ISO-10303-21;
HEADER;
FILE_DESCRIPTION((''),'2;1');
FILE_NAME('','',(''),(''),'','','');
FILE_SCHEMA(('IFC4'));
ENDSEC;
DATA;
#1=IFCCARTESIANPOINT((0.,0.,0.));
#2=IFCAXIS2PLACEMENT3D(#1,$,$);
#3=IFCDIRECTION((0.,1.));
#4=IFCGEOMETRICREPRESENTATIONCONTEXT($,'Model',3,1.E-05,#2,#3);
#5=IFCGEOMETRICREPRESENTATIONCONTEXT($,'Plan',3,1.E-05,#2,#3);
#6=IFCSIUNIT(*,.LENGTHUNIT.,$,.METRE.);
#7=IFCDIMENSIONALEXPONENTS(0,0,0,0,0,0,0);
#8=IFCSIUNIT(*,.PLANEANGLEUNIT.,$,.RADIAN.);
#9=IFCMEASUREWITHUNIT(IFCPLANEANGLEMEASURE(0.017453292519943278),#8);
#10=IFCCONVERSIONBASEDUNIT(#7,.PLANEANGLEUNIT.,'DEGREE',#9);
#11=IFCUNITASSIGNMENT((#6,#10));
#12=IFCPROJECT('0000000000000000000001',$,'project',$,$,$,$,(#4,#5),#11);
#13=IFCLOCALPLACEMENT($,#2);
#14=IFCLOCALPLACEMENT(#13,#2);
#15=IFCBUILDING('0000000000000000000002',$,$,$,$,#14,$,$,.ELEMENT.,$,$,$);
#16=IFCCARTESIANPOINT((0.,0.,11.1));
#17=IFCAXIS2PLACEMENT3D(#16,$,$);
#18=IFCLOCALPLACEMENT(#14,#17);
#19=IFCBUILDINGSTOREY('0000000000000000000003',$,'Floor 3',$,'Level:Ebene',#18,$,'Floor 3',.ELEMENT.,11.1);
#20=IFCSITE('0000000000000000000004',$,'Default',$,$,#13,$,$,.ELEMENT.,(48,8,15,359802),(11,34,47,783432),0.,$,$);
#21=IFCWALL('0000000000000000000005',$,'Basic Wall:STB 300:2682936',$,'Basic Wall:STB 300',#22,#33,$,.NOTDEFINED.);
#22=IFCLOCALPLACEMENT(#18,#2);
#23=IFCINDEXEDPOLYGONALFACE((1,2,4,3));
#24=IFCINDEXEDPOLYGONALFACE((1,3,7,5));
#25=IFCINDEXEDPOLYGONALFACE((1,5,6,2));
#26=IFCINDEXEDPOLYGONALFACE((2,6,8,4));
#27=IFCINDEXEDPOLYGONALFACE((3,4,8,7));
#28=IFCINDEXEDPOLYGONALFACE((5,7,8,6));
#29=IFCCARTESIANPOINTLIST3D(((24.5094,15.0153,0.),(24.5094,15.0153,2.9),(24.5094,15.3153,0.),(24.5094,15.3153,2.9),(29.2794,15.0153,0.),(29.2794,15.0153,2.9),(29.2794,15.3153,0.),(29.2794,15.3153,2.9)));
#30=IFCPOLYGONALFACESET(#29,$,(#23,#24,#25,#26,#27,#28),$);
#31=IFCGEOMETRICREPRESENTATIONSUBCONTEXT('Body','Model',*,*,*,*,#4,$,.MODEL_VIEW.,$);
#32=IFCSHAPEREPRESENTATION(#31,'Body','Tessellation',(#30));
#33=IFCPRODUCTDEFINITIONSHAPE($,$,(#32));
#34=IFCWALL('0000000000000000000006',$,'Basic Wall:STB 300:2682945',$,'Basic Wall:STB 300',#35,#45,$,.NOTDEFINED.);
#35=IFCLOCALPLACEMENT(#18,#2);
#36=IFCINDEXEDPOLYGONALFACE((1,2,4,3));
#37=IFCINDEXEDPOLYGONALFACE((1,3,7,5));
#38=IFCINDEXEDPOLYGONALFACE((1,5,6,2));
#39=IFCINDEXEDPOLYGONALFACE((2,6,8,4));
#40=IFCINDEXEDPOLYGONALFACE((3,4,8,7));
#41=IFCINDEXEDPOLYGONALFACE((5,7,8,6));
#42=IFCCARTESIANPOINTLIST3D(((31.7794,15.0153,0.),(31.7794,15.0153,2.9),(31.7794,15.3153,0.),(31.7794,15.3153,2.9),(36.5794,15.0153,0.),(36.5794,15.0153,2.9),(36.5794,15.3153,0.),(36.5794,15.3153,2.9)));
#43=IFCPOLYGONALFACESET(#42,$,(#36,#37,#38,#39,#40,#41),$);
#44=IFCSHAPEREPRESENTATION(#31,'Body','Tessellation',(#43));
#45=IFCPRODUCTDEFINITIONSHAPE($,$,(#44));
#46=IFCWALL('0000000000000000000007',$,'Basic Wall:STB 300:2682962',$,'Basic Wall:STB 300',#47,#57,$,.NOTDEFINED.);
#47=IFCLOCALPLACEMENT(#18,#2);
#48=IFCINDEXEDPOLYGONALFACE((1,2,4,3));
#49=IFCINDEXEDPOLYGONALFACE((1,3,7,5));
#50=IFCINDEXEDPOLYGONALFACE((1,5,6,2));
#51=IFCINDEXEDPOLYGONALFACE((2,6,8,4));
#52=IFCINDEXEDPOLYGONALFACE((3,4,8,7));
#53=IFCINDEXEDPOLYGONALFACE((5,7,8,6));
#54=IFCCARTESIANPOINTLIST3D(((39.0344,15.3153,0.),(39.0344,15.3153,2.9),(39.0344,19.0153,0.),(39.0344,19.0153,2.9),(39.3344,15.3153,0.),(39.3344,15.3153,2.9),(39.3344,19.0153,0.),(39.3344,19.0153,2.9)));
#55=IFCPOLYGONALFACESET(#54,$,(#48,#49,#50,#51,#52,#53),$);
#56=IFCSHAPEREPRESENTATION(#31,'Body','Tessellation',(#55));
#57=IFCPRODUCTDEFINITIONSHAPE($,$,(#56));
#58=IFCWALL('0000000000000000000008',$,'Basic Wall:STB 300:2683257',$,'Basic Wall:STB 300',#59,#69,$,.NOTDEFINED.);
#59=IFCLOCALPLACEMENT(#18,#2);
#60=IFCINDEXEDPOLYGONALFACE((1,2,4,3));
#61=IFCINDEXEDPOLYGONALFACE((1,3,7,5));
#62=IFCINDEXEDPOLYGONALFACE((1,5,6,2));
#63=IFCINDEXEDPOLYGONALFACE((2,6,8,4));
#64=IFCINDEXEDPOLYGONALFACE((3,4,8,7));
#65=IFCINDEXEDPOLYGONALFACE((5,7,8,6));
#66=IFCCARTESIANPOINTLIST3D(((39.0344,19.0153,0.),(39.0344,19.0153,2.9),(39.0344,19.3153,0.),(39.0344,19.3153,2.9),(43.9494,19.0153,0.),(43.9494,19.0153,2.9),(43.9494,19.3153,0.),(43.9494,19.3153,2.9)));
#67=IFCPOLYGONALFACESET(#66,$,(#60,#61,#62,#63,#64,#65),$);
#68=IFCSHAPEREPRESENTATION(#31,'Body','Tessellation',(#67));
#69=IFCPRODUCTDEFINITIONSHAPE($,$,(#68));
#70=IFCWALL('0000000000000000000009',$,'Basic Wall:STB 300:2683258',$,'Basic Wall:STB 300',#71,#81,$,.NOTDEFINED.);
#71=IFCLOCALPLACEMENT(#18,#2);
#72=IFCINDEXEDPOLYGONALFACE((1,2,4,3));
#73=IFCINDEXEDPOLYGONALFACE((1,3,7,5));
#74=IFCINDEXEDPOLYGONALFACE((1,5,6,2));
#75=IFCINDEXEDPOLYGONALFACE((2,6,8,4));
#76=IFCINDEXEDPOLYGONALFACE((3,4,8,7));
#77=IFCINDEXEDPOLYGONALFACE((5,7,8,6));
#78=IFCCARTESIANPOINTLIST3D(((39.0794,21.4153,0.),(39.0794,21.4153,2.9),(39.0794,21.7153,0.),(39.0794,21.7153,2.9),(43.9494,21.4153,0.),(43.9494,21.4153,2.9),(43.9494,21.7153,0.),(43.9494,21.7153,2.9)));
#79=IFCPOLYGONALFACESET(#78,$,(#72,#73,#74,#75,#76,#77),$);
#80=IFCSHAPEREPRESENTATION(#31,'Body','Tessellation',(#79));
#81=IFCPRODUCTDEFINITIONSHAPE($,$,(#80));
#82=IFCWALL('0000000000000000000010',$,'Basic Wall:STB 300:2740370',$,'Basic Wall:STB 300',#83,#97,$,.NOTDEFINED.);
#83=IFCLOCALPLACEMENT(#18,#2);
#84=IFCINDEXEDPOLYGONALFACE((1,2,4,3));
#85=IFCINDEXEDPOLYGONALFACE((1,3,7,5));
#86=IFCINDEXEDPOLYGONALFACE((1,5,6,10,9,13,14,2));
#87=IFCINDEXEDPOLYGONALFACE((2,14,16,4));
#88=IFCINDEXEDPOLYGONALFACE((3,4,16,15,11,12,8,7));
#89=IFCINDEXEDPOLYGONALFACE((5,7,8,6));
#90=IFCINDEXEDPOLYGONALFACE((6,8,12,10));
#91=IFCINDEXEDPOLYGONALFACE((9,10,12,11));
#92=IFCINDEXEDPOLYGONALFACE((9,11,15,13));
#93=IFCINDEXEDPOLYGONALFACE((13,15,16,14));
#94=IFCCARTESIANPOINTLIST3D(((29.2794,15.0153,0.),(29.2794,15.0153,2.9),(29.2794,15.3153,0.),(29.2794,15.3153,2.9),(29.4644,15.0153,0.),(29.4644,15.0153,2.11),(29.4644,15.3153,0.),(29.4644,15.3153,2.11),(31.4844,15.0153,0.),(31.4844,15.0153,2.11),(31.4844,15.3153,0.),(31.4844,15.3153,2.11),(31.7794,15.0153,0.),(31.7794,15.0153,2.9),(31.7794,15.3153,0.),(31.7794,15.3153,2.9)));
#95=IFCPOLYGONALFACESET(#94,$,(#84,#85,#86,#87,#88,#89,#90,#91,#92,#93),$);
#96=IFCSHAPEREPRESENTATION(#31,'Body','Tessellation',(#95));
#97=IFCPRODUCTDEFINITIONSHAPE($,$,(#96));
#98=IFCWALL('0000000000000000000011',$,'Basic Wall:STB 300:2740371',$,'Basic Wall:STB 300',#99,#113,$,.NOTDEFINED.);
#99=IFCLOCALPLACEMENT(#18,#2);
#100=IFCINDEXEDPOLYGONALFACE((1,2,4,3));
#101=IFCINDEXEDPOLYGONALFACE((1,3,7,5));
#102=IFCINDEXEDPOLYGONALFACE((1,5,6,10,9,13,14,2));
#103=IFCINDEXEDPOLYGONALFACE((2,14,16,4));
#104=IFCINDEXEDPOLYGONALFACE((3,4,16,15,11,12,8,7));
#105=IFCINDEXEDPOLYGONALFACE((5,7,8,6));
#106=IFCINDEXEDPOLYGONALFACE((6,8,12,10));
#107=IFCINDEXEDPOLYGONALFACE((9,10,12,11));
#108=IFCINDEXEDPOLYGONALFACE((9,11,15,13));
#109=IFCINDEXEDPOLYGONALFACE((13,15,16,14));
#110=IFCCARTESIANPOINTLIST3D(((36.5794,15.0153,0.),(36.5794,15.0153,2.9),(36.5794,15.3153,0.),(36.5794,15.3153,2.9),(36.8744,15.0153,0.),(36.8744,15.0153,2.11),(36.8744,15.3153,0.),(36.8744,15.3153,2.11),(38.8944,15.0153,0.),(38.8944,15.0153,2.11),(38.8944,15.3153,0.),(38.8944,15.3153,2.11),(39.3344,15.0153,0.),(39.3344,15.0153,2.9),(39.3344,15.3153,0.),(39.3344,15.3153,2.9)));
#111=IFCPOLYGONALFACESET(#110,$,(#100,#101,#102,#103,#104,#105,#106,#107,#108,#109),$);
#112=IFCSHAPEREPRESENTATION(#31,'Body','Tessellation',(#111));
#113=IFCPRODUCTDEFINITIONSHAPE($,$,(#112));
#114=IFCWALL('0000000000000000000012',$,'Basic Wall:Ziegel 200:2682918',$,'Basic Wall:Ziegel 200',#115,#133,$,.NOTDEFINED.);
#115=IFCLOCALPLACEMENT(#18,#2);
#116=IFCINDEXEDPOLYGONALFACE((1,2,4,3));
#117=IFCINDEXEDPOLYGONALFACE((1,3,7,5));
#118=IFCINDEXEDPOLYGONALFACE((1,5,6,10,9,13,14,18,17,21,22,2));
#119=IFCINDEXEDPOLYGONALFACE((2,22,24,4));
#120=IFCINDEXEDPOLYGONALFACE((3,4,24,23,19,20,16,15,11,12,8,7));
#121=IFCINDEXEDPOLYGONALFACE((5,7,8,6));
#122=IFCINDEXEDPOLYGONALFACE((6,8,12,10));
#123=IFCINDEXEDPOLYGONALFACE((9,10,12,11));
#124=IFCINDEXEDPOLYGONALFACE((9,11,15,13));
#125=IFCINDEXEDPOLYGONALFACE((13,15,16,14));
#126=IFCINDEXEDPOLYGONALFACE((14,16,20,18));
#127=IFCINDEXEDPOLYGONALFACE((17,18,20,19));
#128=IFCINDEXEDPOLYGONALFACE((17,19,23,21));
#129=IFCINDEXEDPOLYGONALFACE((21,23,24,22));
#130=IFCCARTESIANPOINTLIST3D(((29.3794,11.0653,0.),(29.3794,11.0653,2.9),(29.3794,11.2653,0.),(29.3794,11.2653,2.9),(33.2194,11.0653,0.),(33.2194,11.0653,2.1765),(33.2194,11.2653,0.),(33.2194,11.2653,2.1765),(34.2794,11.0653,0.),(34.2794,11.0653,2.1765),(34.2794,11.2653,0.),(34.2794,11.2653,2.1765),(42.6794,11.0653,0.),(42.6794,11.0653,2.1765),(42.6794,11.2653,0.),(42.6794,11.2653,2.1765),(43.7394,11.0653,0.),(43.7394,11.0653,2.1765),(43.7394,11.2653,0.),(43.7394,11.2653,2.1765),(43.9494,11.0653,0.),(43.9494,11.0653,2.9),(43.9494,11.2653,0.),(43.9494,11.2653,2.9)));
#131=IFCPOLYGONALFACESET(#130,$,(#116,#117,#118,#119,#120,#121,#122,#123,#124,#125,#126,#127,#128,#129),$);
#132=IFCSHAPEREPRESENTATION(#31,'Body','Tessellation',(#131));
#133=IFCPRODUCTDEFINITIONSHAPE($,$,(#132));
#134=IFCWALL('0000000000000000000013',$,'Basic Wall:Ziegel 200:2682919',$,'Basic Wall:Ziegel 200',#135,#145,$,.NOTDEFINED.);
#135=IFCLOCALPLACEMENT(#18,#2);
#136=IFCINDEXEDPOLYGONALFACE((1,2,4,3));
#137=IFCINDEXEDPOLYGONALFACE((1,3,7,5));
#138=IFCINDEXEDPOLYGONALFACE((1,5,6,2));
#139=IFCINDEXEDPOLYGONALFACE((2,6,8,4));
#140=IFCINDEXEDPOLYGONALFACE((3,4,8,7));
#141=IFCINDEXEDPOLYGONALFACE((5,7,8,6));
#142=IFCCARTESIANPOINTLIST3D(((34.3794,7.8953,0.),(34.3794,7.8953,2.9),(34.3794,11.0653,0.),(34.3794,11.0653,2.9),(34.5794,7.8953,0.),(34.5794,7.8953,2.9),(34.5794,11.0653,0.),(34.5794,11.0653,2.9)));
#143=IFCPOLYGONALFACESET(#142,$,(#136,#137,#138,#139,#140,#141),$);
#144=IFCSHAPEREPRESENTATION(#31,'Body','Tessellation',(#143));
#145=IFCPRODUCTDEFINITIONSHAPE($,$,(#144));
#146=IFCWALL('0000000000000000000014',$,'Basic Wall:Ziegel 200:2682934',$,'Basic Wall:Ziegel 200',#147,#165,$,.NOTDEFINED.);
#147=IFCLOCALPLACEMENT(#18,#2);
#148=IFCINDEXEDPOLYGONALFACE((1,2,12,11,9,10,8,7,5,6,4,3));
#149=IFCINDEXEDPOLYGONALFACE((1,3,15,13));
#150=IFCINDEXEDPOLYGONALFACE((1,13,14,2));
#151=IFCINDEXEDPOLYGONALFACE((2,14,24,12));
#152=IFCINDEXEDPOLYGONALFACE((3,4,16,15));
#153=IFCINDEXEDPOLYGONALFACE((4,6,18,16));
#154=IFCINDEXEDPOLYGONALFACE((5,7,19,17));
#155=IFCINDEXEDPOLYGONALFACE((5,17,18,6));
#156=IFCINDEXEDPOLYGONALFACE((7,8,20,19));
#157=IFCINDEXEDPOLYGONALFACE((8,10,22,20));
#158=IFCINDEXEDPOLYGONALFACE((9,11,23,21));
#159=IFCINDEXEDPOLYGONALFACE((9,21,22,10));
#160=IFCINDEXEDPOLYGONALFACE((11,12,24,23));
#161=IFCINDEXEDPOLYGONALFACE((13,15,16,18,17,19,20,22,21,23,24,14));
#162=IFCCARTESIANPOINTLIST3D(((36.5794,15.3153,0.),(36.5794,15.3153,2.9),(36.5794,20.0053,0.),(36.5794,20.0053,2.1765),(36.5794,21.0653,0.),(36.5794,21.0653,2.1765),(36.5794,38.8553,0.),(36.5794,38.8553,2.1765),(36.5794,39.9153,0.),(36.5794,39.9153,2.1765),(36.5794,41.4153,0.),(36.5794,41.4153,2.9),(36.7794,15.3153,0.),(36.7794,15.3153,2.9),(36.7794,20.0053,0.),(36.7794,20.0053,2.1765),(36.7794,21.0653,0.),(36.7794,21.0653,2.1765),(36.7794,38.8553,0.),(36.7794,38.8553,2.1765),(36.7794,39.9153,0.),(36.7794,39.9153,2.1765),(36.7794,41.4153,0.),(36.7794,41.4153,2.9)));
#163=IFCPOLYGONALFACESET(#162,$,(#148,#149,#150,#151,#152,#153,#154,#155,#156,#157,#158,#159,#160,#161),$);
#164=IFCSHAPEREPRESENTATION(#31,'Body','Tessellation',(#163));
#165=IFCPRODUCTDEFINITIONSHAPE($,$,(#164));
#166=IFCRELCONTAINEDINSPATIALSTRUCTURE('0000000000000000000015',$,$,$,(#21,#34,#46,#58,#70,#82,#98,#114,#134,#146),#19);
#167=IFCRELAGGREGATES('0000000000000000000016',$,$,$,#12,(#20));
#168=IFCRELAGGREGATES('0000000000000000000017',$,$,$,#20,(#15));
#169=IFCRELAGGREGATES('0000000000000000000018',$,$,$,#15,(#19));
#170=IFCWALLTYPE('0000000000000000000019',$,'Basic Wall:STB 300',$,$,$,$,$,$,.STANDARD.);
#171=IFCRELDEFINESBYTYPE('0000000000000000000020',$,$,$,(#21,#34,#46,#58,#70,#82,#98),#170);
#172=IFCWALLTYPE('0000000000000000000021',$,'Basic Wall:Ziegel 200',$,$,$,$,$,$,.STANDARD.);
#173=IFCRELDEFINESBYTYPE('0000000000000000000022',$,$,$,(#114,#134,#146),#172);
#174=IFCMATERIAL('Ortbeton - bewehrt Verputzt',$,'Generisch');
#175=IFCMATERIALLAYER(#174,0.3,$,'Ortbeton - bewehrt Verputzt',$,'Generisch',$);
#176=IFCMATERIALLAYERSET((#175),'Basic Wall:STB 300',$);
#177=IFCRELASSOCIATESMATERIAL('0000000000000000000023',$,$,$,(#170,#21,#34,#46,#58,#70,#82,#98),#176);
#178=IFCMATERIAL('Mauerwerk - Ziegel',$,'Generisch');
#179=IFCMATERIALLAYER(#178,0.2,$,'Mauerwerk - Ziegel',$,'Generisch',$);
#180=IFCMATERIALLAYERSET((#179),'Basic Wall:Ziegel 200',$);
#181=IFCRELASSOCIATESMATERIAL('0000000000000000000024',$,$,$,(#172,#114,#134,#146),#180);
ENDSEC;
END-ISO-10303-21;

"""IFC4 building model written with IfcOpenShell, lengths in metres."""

from ifc_helpers import new_model, entity, si_unit, converted_unit, direction, frame, frame_2d, origin, place, context, subcontext, project, spatial, rectangle, extrude, material, layer, layer_set, layer_usage, type_object, element, save


model = new_model("IFC4")

# Units and contexts
model_context = context("Model", 3, precision=1e-05, world=origin(), true_north=direction((0.0, 1.0)))
plan_context = context("Plan", 3, precision=1e-05, world=origin(), true_north=direction((0.0, 1.0)))
body_context = subcontext(model_context, "Body", "Model", "MODEL_VIEW")
ifc_project = project(units=[si_unit("LENGTHUNIT", "METRE"), converted_unit("PLANEANGLEUNIT", "DEGREE", entity("IfcPlaneAngleMeasure", 0.017453292519943278), si_unit("PLANEANGLEUNIT", "RADIAN"), dimensions=[0, 0, 0, 0, 0, 0, 0])], contexts=[model_context, plan_context])

# Site, building, storey
site_placement = place(None, origin())
site = spatial("IfcSite", under=ifc_project, at=site_placement, Name="Default", CompositionType="ELEMENT", RefLatitude=(48, 8, 15, 359802), RefLongitude=(11, 34, 47, 783432), RefElevation=0.0)
building_placement = place(site_placement, origin())
building = spatial("IfcBuilding", under=site, at=building_placement, CompositionType="ELEMENT")
storey_placement = place(building_placement, frame((0.0, 0.0, 11.1)))
storey = spatial("IfcBuildingStorey", under=building, at=storey_placement, Name="Floor 3", ObjectType="Level:Ebene", LongName="Floor 3", CompositionType="ELEMENT", Elevation=11.1)

# Walls
ifc_material_1 = material(Name="Ortbeton - bewehrt Verputzt", Category="Generisch")
ifc_layer_1 = layer(ifc_material_1, 0.3, Name="Ortbeton - bewehrt Verputzt", Category="Generisch")
ifc_layer_set_1 = layer_set([ifc_layer_1], Name="Basic Wall:STB 300")
ifc_layer_usage_1 = layer_usage(ifc_layer_set_1, "AXIS2", "NEGATIVE", 0.15)
wall_type_1 = type_object("IfcWallType", Name="Basic Wall:STB 300", PredefinedType="STANDARD", material=ifc_layer_set_1)
wall_1_placement = place(storey_placement, frame((24.5094, 15.1653, 0.0)))
element("IfcWall", 1, at=wall_1_placement, inside=storey, type_object=wall_type_1, material=ifc_layer_usage_1, Name="Basic Wall:STB 300:2682936", ObjectType="Basic Wall:STB 300", PredefinedType="NOTDEFINED", context=body_context, shape_type="SweptSolid", body=[
    extrude(rectangle(XDim=4.77, YDim=0.3, at=frame_2d((2.385, 0.0), x_axis=(-1.0, 0.0))), origin(), (0.0, 0.0, 1.0), 2.9),
])
wall_2_placement = place(storey_placement, frame((31.7794, 15.1653, 0.0)))
element("IfcWall", 2, at=wall_2_placement, inside=storey, type_object=wall_type_1, material=ifc_layer_usage_1, Name="Basic Wall:STB 300:2682945", ObjectType="Basic Wall:STB 300", PredefinedType="NOTDEFINED", context=body_context, shape_type="SweptSolid", body=[
    extrude(rectangle(XDim=4.8, YDim=0.3, at=frame_2d((2.4, 0.0), x_axis=(-1.0, 0.0))), origin(), (0.0, 0.0, 1.0), 2.9),
])
wall_3_placement = place(storey_placement, frame((39.1844, 19.0153, 0.0), z_axis=(0.0, 0.0, 1.0), x_axis=(0.0, -1.0, 0.0)))
element("IfcWall", 3, at=wall_3_placement, inside=storey, type_object=wall_type_1, material=ifc_layer_usage_1, Name="Basic Wall:STB 300:2682962", ObjectType="Basic Wall:STB 300", PredefinedType="NOTDEFINED", context=body_context, shape_type="SweptSolid", body=[
    extrude(rectangle(XDim=3.7, YDim=0.3, at=frame_2d((1.85, 0.0), x_axis=(-1.0, 0.0))), origin(), (0.0, 0.0, 1.0), 2.9),
])
wall_4_placement = place(storey_placement, frame((43.9494, 19.1653, 0.0), z_axis=(0.0, 0.0, 1.0), x_axis=(-1.0, 0.0, 0.0)))
element("IfcWall", 4, at=wall_4_placement, inside=storey, type_object=wall_type_1, material=ifc_layer_usage_1, Name="Basic Wall:STB 300:2683257", ObjectType="Basic Wall:STB 300", PredefinedType="NOTDEFINED", context=body_context, shape_type="SweptSolid", body=[
    extrude(rectangle(XDim=4.915, YDim=0.3, at=frame_2d((2.4575, 0.0), x_axis=(-1.0, 0.0))), origin(), (0.0, 0.0, 1.0), 2.9),
])
wall_5_placement = place(storey_placement, frame((39.0794, 21.5653, 0.0)))
element("IfcWall", 5, at=wall_5_placement, inside=storey, type_object=wall_type_1, material=ifc_layer_usage_1, Name="Basic Wall:STB 300:2683258", ObjectType="Basic Wall:STB 300", PredefinedType="NOTDEFINED", context=body_context, shape_type="SweptSolid", body=[
    extrude(rectangle(XDim=4.87, YDim=0.3, at=frame_2d((2.435, 0.0), x_axis=(-1.0, 0.0))), origin(), (0.0, 0.0, 1.0), 2.9),
])

# Walls, openings
wall_6_placement = place(storey_placement, frame((29.2794, 15.1653, 0.0)))
wall_6 = element("IfcWall", 6, at=wall_6_placement, inside=storey, type_object=wall_type_1, material=ifc_layer_usage_1, Name="Basic Wall:STB 300:2740370", ObjectType="Basic Wall:STB 300", PredefinedType="NOTDEFINED", context=body_context, shape_type="SweptSolid", body=[
    extrude(rectangle(XDim=2.5, YDim=0.3, at=frame_2d((1.25, 0.0), x_axis=(-1.0, 0.0))), origin(), (0.0, 0.0, 1.0), 2.9),
])
opening_1_placement = place(wall_6_placement, frame((0.185, -0.15, 0.0)))
element("IfcOpeningElement", 7, at=opening_1_placement, cuts=wall_6, PredefinedType="OPENING", context=body_context, shape_type="SweptSolid", body=[
    extrude(rectangle(XDim=2.11, YDim=2.02, at=frame_2d((1.055, 1.01), x_axis=(1.0, 0.0))), frame((0.0, 0.0, 0.0), z_axis=(0.0, 1.0, 0.0), x_axis=(0.0, 0.0, 1.0)), (0.0, 0.0, 1.0), 0.3),
])
wall_7_placement = place(storey_placement, frame((36.5794, 15.1653, 0.0)))
wall_7 = element("IfcWall", 8, at=wall_7_placement, inside=storey, type_object=wall_type_1, material=ifc_layer_usage_1, Name="Basic Wall:STB 300:2740371", ObjectType="Basic Wall:STB 300", PredefinedType="NOTDEFINED", context=body_context, shape_type="SweptSolid", body=[
    extrude(rectangle(XDim=2.755, YDim=0.3, at=frame_2d((1.3775, 0.0), x_axis=(-1.0, 0.0))), origin(), (0.0, 0.0, 1.0), 2.9),
])
opening_2_placement = place(wall_7_placement, frame((0.295, -0.15, 0.0)))
element("IfcOpeningElement", 9, at=opening_2_placement, cuts=wall_7, PredefinedType="OPENING", context=body_context, shape_type="SweptSolid", body=[
    extrude(rectangle(XDim=2.11, YDim=2.02, at=frame_2d((1.055, 1.01), x_axis=(1.0, 0.0))), frame((0.0, 0.0, 0.0), z_axis=(0.0, 1.0, 0.0), x_axis=(0.0, 0.0, 1.0)), (0.0, 0.0, 1.0), 0.3),
])

# Wall, openings
ifc_material_2 = material(Name="Mauerwerk - Ziegel", Category="Generisch")
ifc_layer_2 = layer(ifc_material_2, 0.2, Name="Mauerwerk - Ziegel", Category="Generisch")
ifc_layer_set_2 = layer_set([ifc_layer_2], Name="Basic Wall:Ziegel 200")
ifc_layer_usage_2 = layer_usage(ifc_layer_set_2, "AXIS2", "NEGATIVE", 0.1)
wall_type_2 = type_object("IfcWallType", Name="Basic Wall:Ziegel 200", PredefinedType="STANDARD", material=ifc_layer_set_2)
wall_8_placement = place(storey_placement, frame((43.9494, 11.1653, 0.0), z_axis=(0.0, 0.0, 1.0), x_axis=(-1.0, 0.0, 0.0)))
wall_8 = element("IfcWall", 10, at=wall_8_placement, inside=storey, type_object=wall_type_2, material=ifc_layer_usage_2, Name="Basic Wall:Ziegel 200:2682918", ObjectType="Basic Wall:Ziegel 200", PredefinedType="NOTDEFINED", context=body_context, shape_type="SweptSolid", body=[
    extrude(rectangle(XDim=14.57, YDim=0.2, at=frame_2d((7.285, 0.0), x_axis=(1.0, 0.0))), origin(), (0.0, 0.0, 1.0), 2.9),
])
opening_3_placement = place(wall_8_placement, frame((1.27, 0.1, 0.0)))
element("IfcOpeningElement", 11, at=opening_3_placement, cuts=wall_8, PredefinedType="OPENING", context=body_context, shape_type="SweptSolid", body=[
    extrude(rectangle(XDim=2.1765, YDim=1.06, at=frame_2d((1.0882, 0.53), x_axis=(1.0, 0.0))), frame((0.0, 0.0, 0.0), z_axis=(0.0, -1.0, 0.0), x_axis=(0.0, 0.0, 1.0)), (0.0, 0.0, 1.0), 0.2),
])
opening_4_placement = place(wall_8_placement, frame((10.73, 0.1, 0.0)))
element("IfcOpeningElement", 12, at=opening_4_placement, cuts=wall_8, PredefinedType="OPENING", context=body_context, shape_type="SweptSolid", body=[
    extrude(rectangle(XDim=2.1765, YDim=1.06, at=frame_2d((1.0882, 0.53), x_axis=(1.0, 0.0))), frame((0.0, 0.0, 0.0), z_axis=(0.0, -1.0, 0.0), x_axis=(0.0, 0.0, 1.0)), (0.0, 0.0, 1.0), 0.2),
])

# Wall
wall_9_placement = place(storey_placement, frame((34.4794, 11.0653, 0.0), z_axis=(0.0, 0.0, 1.0), x_axis=(0.0, -1.0, 0.0)))
element("IfcWall", 13, at=wall_9_placement, inside=storey, type_object=wall_type_2, material=ifc_layer_usage_2, Name="Basic Wall:Ziegel 200:2682919", ObjectType="Basic Wall:Ziegel 200", PredefinedType="NOTDEFINED", context=body_context, shape_type="SweptSolid", body=[
    extrude(rectangle(XDim=3.17, YDim=0.2, at=frame_2d((1.585, 0.0), x_axis=(-1.0, 0.0))), origin(), (0.0, 0.0, 1.0), 2.9),
])

# Wall, openings
wall_10_placement = place(storey_placement, frame((36.6794, 15.3153, 0.0), z_axis=(0.0, 0.0, 1.0), x_axis=(0.0, 1.0, 0.0)))
wall_10 = element("IfcWall", 14, at=wall_10_placement, inside=storey, type_object=wall_type_2, material=ifc_layer_usage_2, Name="Basic Wall:Ziegel 200:2682934", ObjectType="Basic Wall:Ziegel 200", PredefinedType="NOTDEFINED", context=body_context, shape_type="SweptSolid", body=[
    extrude(rectangle(XDim=26.1, YDim=0.2, at=frame_2d((13.05, 0.0), x_axis=(-1.0, 0.0))), origin(), (0.0, 0.0, 1.0), 2.9),
])
opening_5_placement = place(wall_10_placement, frame((5.75, 0.1, 0.0)))
element("IfcOpeningElement", 15, at=opening_5_placement, cuts=wall_10, PredefinedType="OPENING", context=body_context, shape_type="SweptSolid", body=[
    extrude(rectangle(XDim=2.1765, YDim=1.06, at=frame_2d((1.0882, 0.53), x_axis=(1.0, 0.0))), frame((0.0, 0.0, 0.0), z_axis=(0.0, -1.0, 0.0), x_axis=(0.0, 0.0, 1.0)), (0.0, 0.0, 1.0), 0.2),
])
opening_6_placement = place(wall_10_placement, frame((24.6, 0.1, 0.0)))
element("IfcOpeningElement", 16, at=opening_6_placement, cuts=wall_10, PredefinedType="OPENING", context=body_context, shape_type="SweptSolid", body=[
    extrude(rectangle(XDim=2.1765, YDim=1.06, at=frame_2d((1.0882, 0.53), x_axis=(1.0, 0.0))), frame((0.0, 0.0, 0.0), z_axis=(0.0, -1.0, 0.0), x_axis=(0.0, 0.0, 1.0)), (0.0, 0.0, 1.0), 0.2),
])

save(model, "model.ifc")
